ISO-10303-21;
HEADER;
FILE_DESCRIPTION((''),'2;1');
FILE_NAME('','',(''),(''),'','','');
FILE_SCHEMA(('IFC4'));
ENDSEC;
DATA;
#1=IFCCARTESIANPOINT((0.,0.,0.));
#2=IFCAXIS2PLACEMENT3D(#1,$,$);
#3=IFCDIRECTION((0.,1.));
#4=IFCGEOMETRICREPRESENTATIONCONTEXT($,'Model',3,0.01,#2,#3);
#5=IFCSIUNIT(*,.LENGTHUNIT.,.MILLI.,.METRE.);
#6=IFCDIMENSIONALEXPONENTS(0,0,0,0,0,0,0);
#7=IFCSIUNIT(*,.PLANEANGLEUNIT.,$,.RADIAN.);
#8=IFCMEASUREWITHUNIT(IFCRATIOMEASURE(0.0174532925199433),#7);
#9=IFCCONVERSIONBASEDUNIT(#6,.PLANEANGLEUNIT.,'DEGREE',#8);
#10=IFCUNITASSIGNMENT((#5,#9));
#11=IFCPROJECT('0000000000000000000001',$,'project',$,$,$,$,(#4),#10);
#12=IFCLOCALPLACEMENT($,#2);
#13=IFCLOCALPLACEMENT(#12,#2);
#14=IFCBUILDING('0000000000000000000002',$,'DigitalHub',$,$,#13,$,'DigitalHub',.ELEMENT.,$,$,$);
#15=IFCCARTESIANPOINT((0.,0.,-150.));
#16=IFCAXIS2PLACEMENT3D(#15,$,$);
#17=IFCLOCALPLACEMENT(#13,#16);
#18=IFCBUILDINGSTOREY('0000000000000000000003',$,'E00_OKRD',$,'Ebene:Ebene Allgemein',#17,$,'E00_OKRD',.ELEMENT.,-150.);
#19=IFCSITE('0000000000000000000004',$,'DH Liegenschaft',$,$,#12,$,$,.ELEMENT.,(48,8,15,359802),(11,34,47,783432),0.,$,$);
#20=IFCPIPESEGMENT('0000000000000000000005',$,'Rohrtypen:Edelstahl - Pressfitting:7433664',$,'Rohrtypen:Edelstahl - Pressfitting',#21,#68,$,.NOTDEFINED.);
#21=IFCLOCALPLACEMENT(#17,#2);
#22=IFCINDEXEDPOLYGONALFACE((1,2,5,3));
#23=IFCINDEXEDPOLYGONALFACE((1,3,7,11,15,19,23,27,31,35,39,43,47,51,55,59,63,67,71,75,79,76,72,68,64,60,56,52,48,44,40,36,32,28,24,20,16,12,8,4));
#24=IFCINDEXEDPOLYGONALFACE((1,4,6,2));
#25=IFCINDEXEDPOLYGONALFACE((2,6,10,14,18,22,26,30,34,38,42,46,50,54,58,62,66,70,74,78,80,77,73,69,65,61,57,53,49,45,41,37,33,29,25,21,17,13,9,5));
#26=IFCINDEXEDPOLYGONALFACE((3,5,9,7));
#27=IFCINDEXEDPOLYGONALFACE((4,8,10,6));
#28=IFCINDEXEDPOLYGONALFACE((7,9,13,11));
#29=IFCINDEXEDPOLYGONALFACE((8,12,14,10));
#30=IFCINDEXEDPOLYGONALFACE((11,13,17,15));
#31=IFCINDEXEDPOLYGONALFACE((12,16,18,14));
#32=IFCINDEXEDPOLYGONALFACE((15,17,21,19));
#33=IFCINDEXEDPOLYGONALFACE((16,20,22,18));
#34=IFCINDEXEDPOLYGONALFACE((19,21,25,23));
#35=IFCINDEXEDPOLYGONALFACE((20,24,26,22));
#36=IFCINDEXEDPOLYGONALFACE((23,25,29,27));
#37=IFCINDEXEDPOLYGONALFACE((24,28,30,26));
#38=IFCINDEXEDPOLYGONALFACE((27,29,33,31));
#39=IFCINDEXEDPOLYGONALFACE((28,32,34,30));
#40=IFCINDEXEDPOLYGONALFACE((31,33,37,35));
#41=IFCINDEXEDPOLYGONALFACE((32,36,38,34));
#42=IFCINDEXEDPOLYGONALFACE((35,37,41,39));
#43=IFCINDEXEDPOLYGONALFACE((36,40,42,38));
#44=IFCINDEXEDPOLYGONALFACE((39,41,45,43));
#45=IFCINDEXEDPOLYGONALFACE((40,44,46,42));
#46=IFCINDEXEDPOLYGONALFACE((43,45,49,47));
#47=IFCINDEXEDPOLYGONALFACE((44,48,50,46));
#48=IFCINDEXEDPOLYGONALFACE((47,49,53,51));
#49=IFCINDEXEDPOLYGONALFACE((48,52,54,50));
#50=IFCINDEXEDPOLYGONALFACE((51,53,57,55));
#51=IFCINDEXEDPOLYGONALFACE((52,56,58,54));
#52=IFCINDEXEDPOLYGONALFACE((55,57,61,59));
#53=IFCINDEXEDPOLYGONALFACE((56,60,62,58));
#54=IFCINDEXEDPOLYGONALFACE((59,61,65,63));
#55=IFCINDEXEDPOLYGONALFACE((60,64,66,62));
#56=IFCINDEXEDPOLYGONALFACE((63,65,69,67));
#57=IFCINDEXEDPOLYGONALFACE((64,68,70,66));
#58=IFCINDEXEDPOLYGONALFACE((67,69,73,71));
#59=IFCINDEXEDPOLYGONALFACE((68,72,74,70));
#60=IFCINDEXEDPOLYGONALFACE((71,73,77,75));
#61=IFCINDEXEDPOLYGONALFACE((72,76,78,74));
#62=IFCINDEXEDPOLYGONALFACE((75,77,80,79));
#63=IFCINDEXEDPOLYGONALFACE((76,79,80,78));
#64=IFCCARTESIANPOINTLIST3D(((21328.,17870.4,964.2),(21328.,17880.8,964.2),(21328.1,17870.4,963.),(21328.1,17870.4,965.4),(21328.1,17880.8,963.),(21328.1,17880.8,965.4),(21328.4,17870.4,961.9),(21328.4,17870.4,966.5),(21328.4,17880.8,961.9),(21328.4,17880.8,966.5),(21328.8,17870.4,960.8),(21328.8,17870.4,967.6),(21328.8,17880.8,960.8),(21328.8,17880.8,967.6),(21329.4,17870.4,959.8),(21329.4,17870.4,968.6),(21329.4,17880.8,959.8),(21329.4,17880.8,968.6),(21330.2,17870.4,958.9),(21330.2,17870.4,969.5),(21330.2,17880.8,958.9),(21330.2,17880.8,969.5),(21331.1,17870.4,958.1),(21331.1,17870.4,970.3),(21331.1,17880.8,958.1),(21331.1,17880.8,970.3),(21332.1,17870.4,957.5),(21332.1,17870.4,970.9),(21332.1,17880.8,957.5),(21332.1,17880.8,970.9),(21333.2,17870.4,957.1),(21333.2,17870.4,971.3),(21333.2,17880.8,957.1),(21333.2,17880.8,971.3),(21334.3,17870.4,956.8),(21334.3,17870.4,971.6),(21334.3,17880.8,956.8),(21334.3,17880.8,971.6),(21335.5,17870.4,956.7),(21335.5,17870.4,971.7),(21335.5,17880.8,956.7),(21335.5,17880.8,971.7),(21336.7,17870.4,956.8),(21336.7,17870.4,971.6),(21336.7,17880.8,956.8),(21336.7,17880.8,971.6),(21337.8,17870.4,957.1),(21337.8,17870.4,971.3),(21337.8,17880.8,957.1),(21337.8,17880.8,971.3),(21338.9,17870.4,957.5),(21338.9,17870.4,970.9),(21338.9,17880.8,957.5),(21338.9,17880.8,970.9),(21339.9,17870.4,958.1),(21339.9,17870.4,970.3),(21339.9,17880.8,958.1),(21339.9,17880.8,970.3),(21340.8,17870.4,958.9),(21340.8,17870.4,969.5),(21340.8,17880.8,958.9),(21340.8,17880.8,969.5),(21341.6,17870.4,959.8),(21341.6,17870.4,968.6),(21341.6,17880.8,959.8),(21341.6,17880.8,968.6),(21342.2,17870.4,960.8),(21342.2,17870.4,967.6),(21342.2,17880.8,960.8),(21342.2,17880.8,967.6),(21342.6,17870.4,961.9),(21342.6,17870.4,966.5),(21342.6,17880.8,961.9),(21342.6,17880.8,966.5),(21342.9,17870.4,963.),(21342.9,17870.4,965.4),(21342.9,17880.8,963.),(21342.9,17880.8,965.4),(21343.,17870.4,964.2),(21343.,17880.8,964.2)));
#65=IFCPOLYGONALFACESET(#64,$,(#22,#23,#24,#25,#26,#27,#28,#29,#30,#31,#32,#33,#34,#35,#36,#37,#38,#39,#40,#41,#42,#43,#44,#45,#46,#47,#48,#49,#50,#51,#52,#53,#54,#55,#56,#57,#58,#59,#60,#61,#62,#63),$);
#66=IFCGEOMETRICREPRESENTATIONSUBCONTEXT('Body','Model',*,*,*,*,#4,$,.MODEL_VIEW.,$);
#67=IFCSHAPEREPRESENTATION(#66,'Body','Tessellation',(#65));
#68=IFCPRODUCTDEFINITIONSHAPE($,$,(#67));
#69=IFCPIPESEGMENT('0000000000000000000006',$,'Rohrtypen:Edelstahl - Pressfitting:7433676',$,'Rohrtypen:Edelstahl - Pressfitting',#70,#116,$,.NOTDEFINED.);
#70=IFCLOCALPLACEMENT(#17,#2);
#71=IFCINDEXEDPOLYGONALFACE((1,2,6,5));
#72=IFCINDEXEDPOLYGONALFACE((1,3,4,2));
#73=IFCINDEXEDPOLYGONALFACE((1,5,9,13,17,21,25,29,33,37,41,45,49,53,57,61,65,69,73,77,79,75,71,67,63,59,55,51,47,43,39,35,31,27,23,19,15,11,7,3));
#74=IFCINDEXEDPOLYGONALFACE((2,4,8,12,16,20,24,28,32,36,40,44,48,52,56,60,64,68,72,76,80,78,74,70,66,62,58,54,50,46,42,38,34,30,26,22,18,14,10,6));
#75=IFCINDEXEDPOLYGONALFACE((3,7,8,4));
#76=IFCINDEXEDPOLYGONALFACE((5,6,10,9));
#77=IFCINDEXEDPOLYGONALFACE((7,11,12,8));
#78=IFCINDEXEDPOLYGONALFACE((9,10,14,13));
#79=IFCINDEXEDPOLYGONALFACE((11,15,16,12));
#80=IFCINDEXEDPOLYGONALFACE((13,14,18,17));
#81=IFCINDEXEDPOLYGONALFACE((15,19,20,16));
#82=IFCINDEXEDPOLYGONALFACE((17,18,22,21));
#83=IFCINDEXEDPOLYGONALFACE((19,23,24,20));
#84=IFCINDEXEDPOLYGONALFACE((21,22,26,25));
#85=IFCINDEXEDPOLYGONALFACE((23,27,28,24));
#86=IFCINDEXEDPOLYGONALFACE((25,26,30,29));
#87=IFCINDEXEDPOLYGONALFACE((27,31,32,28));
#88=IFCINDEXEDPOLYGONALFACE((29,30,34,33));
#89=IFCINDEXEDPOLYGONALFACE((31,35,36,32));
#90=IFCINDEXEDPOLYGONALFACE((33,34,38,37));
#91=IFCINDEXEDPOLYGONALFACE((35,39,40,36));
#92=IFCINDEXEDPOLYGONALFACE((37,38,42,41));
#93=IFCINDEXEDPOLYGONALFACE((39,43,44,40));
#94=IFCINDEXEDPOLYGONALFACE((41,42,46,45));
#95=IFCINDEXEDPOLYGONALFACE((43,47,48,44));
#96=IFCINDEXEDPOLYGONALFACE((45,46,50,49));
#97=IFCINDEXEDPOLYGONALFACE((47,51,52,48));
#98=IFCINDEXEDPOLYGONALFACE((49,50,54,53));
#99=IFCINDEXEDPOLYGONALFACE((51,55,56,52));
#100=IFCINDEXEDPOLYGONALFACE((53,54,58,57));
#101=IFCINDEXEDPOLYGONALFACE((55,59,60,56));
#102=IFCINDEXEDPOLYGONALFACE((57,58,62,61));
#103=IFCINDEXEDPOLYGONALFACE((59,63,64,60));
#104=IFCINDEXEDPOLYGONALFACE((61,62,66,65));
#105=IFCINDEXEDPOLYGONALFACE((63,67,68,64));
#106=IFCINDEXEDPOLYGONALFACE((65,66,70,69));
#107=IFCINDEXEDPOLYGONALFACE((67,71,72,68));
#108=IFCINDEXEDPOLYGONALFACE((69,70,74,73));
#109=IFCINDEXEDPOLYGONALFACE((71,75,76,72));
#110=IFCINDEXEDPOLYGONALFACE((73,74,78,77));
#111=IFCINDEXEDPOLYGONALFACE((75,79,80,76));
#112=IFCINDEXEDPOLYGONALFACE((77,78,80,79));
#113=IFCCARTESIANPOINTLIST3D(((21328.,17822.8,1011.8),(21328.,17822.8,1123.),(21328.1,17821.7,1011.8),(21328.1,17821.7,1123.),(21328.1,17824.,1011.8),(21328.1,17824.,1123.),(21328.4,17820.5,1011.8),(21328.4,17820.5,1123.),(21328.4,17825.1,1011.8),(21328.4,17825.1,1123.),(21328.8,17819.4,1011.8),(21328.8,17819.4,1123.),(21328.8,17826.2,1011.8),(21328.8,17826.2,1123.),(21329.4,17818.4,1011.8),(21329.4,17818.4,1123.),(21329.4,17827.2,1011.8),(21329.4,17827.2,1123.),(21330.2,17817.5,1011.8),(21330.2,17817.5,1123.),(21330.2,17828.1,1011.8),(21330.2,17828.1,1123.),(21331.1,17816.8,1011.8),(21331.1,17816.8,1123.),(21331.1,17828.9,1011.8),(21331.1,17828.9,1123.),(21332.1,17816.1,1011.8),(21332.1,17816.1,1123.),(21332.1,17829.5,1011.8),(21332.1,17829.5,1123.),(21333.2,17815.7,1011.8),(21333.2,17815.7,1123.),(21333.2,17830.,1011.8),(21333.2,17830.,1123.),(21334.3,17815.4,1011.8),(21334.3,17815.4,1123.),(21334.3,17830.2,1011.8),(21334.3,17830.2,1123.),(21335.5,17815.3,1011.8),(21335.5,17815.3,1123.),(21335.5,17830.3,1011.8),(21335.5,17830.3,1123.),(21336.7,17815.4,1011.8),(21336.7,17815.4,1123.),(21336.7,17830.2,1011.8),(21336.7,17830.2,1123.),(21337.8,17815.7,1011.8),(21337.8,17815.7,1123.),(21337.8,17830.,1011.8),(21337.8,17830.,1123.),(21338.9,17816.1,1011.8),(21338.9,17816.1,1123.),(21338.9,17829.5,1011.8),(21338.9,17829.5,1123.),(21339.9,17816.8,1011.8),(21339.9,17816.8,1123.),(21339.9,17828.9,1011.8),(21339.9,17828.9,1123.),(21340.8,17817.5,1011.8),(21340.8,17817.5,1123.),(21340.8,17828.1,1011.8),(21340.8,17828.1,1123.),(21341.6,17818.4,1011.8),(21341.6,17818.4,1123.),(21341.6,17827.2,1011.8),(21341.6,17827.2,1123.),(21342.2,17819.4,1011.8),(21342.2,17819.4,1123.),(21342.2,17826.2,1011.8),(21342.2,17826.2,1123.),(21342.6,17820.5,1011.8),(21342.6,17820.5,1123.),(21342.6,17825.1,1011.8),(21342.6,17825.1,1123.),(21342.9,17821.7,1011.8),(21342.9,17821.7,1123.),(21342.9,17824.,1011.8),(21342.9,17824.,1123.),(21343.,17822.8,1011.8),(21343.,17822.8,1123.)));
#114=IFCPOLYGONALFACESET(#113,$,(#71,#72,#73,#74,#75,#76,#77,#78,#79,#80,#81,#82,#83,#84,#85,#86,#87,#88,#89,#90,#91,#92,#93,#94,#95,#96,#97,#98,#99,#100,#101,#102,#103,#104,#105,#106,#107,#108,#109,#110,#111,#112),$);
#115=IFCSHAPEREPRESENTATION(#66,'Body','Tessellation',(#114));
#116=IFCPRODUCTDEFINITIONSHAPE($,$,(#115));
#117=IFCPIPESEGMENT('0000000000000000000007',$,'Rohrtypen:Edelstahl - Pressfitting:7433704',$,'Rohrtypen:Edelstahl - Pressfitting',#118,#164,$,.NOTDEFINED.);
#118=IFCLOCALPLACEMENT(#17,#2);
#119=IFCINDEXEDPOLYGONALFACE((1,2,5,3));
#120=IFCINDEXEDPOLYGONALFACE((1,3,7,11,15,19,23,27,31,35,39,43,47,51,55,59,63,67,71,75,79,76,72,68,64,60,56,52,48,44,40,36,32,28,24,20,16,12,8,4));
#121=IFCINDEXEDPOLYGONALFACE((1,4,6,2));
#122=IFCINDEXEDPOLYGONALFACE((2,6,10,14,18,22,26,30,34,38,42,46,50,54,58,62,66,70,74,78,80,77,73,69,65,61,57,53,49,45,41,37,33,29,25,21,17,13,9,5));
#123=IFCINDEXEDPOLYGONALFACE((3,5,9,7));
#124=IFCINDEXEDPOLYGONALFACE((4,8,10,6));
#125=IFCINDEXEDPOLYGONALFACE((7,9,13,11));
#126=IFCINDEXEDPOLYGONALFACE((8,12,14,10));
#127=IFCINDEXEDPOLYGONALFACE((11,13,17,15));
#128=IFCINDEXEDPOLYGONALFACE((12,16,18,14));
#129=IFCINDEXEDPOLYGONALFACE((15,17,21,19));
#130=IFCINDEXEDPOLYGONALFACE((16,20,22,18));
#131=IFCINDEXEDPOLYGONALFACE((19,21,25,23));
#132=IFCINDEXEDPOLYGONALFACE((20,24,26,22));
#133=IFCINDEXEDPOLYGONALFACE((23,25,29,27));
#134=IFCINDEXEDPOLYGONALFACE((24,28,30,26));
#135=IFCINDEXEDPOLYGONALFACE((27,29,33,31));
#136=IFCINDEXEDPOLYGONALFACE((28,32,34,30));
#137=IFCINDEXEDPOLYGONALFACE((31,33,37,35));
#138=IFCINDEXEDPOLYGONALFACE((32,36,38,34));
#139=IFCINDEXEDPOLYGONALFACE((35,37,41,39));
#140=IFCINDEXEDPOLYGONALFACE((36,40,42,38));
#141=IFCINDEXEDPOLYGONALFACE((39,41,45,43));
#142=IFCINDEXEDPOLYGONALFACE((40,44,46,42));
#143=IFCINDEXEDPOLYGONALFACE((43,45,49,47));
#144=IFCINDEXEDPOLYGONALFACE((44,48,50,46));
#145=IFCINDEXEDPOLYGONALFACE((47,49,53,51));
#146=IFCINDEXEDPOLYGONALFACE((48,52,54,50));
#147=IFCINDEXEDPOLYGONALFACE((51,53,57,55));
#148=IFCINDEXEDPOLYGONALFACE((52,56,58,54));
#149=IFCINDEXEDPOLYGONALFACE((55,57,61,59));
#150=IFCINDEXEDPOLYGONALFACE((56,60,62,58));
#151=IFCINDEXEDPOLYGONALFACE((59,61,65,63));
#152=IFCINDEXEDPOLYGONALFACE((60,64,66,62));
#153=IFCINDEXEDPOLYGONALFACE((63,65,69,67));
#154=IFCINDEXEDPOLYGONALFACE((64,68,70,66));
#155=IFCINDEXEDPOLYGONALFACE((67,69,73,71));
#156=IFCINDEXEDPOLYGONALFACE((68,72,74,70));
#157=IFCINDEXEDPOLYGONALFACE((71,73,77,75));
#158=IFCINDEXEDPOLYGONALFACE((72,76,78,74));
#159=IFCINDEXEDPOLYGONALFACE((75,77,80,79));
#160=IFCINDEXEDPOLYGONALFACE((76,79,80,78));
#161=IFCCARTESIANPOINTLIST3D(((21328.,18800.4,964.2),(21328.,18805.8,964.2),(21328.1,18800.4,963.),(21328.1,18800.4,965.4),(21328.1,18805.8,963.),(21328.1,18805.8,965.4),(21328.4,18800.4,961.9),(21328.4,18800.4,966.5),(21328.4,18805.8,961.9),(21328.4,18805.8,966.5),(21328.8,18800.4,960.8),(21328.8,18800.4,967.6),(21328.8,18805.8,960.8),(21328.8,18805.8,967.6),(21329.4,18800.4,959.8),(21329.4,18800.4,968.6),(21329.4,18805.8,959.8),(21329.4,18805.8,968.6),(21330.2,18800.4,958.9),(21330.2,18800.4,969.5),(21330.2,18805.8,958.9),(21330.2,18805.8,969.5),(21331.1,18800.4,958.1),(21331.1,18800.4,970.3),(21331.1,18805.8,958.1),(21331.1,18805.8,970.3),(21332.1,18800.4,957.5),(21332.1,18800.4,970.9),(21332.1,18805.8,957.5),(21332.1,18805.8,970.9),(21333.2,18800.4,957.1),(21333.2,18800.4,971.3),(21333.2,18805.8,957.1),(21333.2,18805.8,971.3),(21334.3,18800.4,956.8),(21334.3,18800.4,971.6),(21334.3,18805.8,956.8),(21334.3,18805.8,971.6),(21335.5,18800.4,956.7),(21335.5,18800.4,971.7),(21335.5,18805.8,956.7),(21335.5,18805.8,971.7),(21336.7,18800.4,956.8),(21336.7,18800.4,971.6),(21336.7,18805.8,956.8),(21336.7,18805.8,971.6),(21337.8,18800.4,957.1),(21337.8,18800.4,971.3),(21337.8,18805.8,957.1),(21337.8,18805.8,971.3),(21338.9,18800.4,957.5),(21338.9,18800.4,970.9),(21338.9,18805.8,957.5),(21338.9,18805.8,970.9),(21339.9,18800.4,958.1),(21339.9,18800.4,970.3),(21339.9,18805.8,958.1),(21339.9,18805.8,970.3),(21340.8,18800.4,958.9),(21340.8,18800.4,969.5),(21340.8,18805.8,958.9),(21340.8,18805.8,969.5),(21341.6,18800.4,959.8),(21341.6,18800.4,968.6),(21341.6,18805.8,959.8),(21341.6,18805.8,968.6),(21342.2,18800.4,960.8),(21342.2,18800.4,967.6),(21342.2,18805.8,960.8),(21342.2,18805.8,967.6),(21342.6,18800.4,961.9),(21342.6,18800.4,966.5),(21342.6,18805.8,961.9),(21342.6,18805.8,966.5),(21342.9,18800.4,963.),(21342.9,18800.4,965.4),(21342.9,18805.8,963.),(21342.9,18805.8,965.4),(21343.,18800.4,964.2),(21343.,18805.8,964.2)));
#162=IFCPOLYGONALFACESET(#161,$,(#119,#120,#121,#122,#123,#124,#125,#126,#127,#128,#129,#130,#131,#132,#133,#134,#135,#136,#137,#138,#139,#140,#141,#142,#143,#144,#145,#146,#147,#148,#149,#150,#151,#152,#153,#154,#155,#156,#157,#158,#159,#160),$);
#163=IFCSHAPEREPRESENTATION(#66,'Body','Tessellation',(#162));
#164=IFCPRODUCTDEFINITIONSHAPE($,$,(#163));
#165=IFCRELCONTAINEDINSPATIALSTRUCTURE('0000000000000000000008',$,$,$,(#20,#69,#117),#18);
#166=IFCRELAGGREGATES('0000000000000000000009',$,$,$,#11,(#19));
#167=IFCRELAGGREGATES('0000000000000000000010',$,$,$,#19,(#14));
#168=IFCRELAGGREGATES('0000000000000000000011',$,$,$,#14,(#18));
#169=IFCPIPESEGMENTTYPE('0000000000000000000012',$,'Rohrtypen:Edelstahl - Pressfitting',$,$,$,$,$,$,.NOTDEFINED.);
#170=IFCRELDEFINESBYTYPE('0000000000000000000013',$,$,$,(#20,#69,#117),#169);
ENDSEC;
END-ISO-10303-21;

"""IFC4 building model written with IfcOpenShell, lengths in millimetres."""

from ifc_helpers import new_model, entity, si_unit, converted_unit, direction, frame, origin, place, context, subcontext, project, spatial, indexed_curve, outline, extrude, type_object, element, save


model = new_model("IFC4")

# Units and contexts
model_context = context("Model", 3, precision=0.01, world=origin(), true_north=direction((0.0, 1.0)))
body_context = subcontext(model_context, "Body", "Model", "MODEL_VIEW")
ifc_project = project(units=[si_unit("LENGTHUNIT", "METRE", prefix="MILLI"), converted_unit("PLANEANGLEUNIT", "DEGREE", entity("IfcRatioMeasure", 0.0174532925199433), si_unit("PLANEANGLEUNIT", "RADIAN"), dimensions=[0, 0, 0, 0, 0, 0, 0])], contexts=[model_context])

# Site, building, storey
site_placement = place(None, origin())
site = spatial("IfcSite", under=ifc_project, at=site_placement, Name="DH Liegenschaft", CompositionType="ELEMENT", RefLatitude=(48, 8, 15, 359802), RefLongitude=(11, 34, 47, 783432), RefElevation=0.0)
building_placement = place(site_placement, origin())
building = spatial("IfcBuilding", under=site, at=building_placement, Name="DigitalHub", LongName="DigitalHub", CompositionType="ELEMENT")
storey_placement = place(building_placement, frame((0.0, 0.0, -150.0)))
storey = spatial("IfcBuildingStorey", under=building, at=storey_placement, Name="E00_OKRD", ObjectType="Ebene:Ebene Allgemein", LongName="E00_OKRD", CompositionType="ELEMENT", Elevation=-150.0)

# Pipe segments
pipe_segment_type_1 = type_object("IfcPipeSegmentType", Name="Rohrtypen:Edelstahl - Pressfitting", PredefinedType="NOTDEFINED")
pipe_segment_1_placement = place(storey_placement, frame((21326.4, 17870.4, 955.1)))
element("IfcPipeSegment", 1, at=pipe_segment_1_placement, inside=storey, type_object=pipe_segment_type_1, Name="Rohrtypen:Edelstahl - Pressfitting:7433664", ObjectType="Rohrtypen:Edelstahl - Pressfitting", PredefinedType="NOTDEFINED", context=body_context, shape_type="SweptSolid", body=[
    extrude(outline(indexed_curve([(7.5, 0.0), (7.4, 1.2), (7.1, 2.3), (6.7, 3.4), (6.1, 4.4), (5.3, 5.3), (4.4, 6.1), (3.4, 6.7), (2.3, 7.1), (1.2, 7.4), (0.0, 7.5), (-1.2, 7.4), (-2.3, 7.1), (-3.4, 6.7), (-4.4, 6.1), (-5.3, 5.3), (-6.1, 4.4), (-6.7, 3.4), (-7.1, 2.3), (-7.4, 1.2), (-7.5, 0.0), (-7.4, -1.2), (-7.1, -2.3), (-6.7, -3.4), (-6.1, -4.4), (-5.3, -5.3), (-4.4, -6.1), (-3.4, -6.7), (-2.3, -7.1), (-1.2, -7.4), (0.0, -7.5), (1.2, -7.4), (2.3, -7.1), (3.4, -6.7), (4.4, -6.1), (5.3, -5.3), (6.1, -4.4), (6.7, -3.4), (7.1, -2.3), (7.4, -1.2), (7.5, 0.0)], self_intersect=False)), frame((9.1, 0.0, 9.1), z_axis=(0.0, 1.0, 0.0), x_axis=(-1.0, 0.0, 0.0)), (0.0, 0.0, 1.0), 10.4),
])
pipe_segment_2_placement = place(storey_placement, frame((21326.4, 17813.7, 1011.8)))
element("IfcPipeSegment", 2, at=pipe_segment_2_placement, inside=storey, type_object=pipe_segment_type_1, Name="Rohrtypen:Edelstahl - Pressfitting:7433676", ObjectType="Rohrtypen:Edelstahl - Pressfitting", PredefinedType="NOTDEFINED", context=body_context, shape_type="SweptSolid", body=[
    extrude(outline(indexed_curve([(7.5, 0.0), (7.4, 1.2), (7.1, 2.3), (6.7, 3.4), (6.1, 4.4), (5.3, 5.3), (4.4, 6.1), (3.4, 6.7), (2.3, 7.1), (1.2, 7.4), (0.0, 7.5), (-1.2, 7.4), (-2.3, 7.1), (-3.4, 6.7), (-4.4, 6.1), (-5.3, 5.3), (-6.1, 4.4), (-6.7, 3.4), (-7.1, 2.3), (-7.4, 1.2), (-7.5, 0.0), (-7.4, -1.2), (-7.1, -2.3), (-6.7, -3.4), (-6.1, -4.4), (-5.3, -5.3), (-4.4, -6.1), (-3.4, -6.7), (-2.3, -7.1), (-1.2, -7.4), (0.0, -7.5), (1.2, -7.4), (2.3, -7.1), (3.4, -6.7), (4.4, -6.1), (5.3, -5.3), (6.1, -4.4), (6.7, -3.4), (7.1, -2.3), (7.4, -1.2), (7.5, 0.0)], self_intersect=False)), frame((9.1, 9.1, 0.0), z_axis=(-0.000005, 0.0, 1.0), x_axis=(-1.0, 0.0, -0.000005)), (0.0, 0.0, 1.0), 111.2),
])
pipe_segment_3_placement = place(storey_placement, frame((21326.4, 18800.4, 955.1)))
element("IfcPipeSegment", 3, at=pipe_segment_3_placement, inside=storey, type_object=pipe_segment_type_1, Name="Rohrtypen:Edelstahl - Pressfitting:7433704", ObjectType="Rohrtypen:Edelstahl - Pressfitting", PredefinedType="NOTDEFINED", context=body_context, shape_type="SweptSolid", body=[
    extrude(outline(indexed_curve([(7.5, 0.0), (7.4, 1.2), (7.1, 2.3), (6.7, 3.4), (6.1, 4.4), (5.3, 5.3), (4.4, 6.1), (3.4, 6.7), (2.3, 7.1), (1.2, 7.4), (0.0, 7.5), (-1.2, 7.4), (-2.3, 7.1), (-3.4, 6.7), (-4.4, 6.1), (-5.3, 5.3), (-6.1, 4.4), (-6.7, 3.4), (-7.1, 2.3), (-7.4, 1.2), (-7.5, 0.0), (-7.4, -1.2), (-7.1, -2.3), (-6.7, -3.4), (-6.1, -4.4), (-5.3, -5.3), (-4.4, -6.1), (-3.4, -6.7), (-2.3, -7.1), (-1.2, -7.4), (0.0, -7.5), (1.2, -7.4), (2.3, -7.1), (3.4, -6.7), (4.4, -6.1), (5.3, -5.3), (6.1, -4.4), (6.7, -3.4), (7.1, -2.3), (7.4, -1.2), (7.5, 0.0)], self_intersect=False)), frame((9.1, 0.0, 9.1), z_axis=(0.0, 1.0, 0.0), x_axis=(-1.0, 0.0, 0.0)), (0.0, 0.0, 1.0), 5.4),
])

save(model, "model.ifc")
